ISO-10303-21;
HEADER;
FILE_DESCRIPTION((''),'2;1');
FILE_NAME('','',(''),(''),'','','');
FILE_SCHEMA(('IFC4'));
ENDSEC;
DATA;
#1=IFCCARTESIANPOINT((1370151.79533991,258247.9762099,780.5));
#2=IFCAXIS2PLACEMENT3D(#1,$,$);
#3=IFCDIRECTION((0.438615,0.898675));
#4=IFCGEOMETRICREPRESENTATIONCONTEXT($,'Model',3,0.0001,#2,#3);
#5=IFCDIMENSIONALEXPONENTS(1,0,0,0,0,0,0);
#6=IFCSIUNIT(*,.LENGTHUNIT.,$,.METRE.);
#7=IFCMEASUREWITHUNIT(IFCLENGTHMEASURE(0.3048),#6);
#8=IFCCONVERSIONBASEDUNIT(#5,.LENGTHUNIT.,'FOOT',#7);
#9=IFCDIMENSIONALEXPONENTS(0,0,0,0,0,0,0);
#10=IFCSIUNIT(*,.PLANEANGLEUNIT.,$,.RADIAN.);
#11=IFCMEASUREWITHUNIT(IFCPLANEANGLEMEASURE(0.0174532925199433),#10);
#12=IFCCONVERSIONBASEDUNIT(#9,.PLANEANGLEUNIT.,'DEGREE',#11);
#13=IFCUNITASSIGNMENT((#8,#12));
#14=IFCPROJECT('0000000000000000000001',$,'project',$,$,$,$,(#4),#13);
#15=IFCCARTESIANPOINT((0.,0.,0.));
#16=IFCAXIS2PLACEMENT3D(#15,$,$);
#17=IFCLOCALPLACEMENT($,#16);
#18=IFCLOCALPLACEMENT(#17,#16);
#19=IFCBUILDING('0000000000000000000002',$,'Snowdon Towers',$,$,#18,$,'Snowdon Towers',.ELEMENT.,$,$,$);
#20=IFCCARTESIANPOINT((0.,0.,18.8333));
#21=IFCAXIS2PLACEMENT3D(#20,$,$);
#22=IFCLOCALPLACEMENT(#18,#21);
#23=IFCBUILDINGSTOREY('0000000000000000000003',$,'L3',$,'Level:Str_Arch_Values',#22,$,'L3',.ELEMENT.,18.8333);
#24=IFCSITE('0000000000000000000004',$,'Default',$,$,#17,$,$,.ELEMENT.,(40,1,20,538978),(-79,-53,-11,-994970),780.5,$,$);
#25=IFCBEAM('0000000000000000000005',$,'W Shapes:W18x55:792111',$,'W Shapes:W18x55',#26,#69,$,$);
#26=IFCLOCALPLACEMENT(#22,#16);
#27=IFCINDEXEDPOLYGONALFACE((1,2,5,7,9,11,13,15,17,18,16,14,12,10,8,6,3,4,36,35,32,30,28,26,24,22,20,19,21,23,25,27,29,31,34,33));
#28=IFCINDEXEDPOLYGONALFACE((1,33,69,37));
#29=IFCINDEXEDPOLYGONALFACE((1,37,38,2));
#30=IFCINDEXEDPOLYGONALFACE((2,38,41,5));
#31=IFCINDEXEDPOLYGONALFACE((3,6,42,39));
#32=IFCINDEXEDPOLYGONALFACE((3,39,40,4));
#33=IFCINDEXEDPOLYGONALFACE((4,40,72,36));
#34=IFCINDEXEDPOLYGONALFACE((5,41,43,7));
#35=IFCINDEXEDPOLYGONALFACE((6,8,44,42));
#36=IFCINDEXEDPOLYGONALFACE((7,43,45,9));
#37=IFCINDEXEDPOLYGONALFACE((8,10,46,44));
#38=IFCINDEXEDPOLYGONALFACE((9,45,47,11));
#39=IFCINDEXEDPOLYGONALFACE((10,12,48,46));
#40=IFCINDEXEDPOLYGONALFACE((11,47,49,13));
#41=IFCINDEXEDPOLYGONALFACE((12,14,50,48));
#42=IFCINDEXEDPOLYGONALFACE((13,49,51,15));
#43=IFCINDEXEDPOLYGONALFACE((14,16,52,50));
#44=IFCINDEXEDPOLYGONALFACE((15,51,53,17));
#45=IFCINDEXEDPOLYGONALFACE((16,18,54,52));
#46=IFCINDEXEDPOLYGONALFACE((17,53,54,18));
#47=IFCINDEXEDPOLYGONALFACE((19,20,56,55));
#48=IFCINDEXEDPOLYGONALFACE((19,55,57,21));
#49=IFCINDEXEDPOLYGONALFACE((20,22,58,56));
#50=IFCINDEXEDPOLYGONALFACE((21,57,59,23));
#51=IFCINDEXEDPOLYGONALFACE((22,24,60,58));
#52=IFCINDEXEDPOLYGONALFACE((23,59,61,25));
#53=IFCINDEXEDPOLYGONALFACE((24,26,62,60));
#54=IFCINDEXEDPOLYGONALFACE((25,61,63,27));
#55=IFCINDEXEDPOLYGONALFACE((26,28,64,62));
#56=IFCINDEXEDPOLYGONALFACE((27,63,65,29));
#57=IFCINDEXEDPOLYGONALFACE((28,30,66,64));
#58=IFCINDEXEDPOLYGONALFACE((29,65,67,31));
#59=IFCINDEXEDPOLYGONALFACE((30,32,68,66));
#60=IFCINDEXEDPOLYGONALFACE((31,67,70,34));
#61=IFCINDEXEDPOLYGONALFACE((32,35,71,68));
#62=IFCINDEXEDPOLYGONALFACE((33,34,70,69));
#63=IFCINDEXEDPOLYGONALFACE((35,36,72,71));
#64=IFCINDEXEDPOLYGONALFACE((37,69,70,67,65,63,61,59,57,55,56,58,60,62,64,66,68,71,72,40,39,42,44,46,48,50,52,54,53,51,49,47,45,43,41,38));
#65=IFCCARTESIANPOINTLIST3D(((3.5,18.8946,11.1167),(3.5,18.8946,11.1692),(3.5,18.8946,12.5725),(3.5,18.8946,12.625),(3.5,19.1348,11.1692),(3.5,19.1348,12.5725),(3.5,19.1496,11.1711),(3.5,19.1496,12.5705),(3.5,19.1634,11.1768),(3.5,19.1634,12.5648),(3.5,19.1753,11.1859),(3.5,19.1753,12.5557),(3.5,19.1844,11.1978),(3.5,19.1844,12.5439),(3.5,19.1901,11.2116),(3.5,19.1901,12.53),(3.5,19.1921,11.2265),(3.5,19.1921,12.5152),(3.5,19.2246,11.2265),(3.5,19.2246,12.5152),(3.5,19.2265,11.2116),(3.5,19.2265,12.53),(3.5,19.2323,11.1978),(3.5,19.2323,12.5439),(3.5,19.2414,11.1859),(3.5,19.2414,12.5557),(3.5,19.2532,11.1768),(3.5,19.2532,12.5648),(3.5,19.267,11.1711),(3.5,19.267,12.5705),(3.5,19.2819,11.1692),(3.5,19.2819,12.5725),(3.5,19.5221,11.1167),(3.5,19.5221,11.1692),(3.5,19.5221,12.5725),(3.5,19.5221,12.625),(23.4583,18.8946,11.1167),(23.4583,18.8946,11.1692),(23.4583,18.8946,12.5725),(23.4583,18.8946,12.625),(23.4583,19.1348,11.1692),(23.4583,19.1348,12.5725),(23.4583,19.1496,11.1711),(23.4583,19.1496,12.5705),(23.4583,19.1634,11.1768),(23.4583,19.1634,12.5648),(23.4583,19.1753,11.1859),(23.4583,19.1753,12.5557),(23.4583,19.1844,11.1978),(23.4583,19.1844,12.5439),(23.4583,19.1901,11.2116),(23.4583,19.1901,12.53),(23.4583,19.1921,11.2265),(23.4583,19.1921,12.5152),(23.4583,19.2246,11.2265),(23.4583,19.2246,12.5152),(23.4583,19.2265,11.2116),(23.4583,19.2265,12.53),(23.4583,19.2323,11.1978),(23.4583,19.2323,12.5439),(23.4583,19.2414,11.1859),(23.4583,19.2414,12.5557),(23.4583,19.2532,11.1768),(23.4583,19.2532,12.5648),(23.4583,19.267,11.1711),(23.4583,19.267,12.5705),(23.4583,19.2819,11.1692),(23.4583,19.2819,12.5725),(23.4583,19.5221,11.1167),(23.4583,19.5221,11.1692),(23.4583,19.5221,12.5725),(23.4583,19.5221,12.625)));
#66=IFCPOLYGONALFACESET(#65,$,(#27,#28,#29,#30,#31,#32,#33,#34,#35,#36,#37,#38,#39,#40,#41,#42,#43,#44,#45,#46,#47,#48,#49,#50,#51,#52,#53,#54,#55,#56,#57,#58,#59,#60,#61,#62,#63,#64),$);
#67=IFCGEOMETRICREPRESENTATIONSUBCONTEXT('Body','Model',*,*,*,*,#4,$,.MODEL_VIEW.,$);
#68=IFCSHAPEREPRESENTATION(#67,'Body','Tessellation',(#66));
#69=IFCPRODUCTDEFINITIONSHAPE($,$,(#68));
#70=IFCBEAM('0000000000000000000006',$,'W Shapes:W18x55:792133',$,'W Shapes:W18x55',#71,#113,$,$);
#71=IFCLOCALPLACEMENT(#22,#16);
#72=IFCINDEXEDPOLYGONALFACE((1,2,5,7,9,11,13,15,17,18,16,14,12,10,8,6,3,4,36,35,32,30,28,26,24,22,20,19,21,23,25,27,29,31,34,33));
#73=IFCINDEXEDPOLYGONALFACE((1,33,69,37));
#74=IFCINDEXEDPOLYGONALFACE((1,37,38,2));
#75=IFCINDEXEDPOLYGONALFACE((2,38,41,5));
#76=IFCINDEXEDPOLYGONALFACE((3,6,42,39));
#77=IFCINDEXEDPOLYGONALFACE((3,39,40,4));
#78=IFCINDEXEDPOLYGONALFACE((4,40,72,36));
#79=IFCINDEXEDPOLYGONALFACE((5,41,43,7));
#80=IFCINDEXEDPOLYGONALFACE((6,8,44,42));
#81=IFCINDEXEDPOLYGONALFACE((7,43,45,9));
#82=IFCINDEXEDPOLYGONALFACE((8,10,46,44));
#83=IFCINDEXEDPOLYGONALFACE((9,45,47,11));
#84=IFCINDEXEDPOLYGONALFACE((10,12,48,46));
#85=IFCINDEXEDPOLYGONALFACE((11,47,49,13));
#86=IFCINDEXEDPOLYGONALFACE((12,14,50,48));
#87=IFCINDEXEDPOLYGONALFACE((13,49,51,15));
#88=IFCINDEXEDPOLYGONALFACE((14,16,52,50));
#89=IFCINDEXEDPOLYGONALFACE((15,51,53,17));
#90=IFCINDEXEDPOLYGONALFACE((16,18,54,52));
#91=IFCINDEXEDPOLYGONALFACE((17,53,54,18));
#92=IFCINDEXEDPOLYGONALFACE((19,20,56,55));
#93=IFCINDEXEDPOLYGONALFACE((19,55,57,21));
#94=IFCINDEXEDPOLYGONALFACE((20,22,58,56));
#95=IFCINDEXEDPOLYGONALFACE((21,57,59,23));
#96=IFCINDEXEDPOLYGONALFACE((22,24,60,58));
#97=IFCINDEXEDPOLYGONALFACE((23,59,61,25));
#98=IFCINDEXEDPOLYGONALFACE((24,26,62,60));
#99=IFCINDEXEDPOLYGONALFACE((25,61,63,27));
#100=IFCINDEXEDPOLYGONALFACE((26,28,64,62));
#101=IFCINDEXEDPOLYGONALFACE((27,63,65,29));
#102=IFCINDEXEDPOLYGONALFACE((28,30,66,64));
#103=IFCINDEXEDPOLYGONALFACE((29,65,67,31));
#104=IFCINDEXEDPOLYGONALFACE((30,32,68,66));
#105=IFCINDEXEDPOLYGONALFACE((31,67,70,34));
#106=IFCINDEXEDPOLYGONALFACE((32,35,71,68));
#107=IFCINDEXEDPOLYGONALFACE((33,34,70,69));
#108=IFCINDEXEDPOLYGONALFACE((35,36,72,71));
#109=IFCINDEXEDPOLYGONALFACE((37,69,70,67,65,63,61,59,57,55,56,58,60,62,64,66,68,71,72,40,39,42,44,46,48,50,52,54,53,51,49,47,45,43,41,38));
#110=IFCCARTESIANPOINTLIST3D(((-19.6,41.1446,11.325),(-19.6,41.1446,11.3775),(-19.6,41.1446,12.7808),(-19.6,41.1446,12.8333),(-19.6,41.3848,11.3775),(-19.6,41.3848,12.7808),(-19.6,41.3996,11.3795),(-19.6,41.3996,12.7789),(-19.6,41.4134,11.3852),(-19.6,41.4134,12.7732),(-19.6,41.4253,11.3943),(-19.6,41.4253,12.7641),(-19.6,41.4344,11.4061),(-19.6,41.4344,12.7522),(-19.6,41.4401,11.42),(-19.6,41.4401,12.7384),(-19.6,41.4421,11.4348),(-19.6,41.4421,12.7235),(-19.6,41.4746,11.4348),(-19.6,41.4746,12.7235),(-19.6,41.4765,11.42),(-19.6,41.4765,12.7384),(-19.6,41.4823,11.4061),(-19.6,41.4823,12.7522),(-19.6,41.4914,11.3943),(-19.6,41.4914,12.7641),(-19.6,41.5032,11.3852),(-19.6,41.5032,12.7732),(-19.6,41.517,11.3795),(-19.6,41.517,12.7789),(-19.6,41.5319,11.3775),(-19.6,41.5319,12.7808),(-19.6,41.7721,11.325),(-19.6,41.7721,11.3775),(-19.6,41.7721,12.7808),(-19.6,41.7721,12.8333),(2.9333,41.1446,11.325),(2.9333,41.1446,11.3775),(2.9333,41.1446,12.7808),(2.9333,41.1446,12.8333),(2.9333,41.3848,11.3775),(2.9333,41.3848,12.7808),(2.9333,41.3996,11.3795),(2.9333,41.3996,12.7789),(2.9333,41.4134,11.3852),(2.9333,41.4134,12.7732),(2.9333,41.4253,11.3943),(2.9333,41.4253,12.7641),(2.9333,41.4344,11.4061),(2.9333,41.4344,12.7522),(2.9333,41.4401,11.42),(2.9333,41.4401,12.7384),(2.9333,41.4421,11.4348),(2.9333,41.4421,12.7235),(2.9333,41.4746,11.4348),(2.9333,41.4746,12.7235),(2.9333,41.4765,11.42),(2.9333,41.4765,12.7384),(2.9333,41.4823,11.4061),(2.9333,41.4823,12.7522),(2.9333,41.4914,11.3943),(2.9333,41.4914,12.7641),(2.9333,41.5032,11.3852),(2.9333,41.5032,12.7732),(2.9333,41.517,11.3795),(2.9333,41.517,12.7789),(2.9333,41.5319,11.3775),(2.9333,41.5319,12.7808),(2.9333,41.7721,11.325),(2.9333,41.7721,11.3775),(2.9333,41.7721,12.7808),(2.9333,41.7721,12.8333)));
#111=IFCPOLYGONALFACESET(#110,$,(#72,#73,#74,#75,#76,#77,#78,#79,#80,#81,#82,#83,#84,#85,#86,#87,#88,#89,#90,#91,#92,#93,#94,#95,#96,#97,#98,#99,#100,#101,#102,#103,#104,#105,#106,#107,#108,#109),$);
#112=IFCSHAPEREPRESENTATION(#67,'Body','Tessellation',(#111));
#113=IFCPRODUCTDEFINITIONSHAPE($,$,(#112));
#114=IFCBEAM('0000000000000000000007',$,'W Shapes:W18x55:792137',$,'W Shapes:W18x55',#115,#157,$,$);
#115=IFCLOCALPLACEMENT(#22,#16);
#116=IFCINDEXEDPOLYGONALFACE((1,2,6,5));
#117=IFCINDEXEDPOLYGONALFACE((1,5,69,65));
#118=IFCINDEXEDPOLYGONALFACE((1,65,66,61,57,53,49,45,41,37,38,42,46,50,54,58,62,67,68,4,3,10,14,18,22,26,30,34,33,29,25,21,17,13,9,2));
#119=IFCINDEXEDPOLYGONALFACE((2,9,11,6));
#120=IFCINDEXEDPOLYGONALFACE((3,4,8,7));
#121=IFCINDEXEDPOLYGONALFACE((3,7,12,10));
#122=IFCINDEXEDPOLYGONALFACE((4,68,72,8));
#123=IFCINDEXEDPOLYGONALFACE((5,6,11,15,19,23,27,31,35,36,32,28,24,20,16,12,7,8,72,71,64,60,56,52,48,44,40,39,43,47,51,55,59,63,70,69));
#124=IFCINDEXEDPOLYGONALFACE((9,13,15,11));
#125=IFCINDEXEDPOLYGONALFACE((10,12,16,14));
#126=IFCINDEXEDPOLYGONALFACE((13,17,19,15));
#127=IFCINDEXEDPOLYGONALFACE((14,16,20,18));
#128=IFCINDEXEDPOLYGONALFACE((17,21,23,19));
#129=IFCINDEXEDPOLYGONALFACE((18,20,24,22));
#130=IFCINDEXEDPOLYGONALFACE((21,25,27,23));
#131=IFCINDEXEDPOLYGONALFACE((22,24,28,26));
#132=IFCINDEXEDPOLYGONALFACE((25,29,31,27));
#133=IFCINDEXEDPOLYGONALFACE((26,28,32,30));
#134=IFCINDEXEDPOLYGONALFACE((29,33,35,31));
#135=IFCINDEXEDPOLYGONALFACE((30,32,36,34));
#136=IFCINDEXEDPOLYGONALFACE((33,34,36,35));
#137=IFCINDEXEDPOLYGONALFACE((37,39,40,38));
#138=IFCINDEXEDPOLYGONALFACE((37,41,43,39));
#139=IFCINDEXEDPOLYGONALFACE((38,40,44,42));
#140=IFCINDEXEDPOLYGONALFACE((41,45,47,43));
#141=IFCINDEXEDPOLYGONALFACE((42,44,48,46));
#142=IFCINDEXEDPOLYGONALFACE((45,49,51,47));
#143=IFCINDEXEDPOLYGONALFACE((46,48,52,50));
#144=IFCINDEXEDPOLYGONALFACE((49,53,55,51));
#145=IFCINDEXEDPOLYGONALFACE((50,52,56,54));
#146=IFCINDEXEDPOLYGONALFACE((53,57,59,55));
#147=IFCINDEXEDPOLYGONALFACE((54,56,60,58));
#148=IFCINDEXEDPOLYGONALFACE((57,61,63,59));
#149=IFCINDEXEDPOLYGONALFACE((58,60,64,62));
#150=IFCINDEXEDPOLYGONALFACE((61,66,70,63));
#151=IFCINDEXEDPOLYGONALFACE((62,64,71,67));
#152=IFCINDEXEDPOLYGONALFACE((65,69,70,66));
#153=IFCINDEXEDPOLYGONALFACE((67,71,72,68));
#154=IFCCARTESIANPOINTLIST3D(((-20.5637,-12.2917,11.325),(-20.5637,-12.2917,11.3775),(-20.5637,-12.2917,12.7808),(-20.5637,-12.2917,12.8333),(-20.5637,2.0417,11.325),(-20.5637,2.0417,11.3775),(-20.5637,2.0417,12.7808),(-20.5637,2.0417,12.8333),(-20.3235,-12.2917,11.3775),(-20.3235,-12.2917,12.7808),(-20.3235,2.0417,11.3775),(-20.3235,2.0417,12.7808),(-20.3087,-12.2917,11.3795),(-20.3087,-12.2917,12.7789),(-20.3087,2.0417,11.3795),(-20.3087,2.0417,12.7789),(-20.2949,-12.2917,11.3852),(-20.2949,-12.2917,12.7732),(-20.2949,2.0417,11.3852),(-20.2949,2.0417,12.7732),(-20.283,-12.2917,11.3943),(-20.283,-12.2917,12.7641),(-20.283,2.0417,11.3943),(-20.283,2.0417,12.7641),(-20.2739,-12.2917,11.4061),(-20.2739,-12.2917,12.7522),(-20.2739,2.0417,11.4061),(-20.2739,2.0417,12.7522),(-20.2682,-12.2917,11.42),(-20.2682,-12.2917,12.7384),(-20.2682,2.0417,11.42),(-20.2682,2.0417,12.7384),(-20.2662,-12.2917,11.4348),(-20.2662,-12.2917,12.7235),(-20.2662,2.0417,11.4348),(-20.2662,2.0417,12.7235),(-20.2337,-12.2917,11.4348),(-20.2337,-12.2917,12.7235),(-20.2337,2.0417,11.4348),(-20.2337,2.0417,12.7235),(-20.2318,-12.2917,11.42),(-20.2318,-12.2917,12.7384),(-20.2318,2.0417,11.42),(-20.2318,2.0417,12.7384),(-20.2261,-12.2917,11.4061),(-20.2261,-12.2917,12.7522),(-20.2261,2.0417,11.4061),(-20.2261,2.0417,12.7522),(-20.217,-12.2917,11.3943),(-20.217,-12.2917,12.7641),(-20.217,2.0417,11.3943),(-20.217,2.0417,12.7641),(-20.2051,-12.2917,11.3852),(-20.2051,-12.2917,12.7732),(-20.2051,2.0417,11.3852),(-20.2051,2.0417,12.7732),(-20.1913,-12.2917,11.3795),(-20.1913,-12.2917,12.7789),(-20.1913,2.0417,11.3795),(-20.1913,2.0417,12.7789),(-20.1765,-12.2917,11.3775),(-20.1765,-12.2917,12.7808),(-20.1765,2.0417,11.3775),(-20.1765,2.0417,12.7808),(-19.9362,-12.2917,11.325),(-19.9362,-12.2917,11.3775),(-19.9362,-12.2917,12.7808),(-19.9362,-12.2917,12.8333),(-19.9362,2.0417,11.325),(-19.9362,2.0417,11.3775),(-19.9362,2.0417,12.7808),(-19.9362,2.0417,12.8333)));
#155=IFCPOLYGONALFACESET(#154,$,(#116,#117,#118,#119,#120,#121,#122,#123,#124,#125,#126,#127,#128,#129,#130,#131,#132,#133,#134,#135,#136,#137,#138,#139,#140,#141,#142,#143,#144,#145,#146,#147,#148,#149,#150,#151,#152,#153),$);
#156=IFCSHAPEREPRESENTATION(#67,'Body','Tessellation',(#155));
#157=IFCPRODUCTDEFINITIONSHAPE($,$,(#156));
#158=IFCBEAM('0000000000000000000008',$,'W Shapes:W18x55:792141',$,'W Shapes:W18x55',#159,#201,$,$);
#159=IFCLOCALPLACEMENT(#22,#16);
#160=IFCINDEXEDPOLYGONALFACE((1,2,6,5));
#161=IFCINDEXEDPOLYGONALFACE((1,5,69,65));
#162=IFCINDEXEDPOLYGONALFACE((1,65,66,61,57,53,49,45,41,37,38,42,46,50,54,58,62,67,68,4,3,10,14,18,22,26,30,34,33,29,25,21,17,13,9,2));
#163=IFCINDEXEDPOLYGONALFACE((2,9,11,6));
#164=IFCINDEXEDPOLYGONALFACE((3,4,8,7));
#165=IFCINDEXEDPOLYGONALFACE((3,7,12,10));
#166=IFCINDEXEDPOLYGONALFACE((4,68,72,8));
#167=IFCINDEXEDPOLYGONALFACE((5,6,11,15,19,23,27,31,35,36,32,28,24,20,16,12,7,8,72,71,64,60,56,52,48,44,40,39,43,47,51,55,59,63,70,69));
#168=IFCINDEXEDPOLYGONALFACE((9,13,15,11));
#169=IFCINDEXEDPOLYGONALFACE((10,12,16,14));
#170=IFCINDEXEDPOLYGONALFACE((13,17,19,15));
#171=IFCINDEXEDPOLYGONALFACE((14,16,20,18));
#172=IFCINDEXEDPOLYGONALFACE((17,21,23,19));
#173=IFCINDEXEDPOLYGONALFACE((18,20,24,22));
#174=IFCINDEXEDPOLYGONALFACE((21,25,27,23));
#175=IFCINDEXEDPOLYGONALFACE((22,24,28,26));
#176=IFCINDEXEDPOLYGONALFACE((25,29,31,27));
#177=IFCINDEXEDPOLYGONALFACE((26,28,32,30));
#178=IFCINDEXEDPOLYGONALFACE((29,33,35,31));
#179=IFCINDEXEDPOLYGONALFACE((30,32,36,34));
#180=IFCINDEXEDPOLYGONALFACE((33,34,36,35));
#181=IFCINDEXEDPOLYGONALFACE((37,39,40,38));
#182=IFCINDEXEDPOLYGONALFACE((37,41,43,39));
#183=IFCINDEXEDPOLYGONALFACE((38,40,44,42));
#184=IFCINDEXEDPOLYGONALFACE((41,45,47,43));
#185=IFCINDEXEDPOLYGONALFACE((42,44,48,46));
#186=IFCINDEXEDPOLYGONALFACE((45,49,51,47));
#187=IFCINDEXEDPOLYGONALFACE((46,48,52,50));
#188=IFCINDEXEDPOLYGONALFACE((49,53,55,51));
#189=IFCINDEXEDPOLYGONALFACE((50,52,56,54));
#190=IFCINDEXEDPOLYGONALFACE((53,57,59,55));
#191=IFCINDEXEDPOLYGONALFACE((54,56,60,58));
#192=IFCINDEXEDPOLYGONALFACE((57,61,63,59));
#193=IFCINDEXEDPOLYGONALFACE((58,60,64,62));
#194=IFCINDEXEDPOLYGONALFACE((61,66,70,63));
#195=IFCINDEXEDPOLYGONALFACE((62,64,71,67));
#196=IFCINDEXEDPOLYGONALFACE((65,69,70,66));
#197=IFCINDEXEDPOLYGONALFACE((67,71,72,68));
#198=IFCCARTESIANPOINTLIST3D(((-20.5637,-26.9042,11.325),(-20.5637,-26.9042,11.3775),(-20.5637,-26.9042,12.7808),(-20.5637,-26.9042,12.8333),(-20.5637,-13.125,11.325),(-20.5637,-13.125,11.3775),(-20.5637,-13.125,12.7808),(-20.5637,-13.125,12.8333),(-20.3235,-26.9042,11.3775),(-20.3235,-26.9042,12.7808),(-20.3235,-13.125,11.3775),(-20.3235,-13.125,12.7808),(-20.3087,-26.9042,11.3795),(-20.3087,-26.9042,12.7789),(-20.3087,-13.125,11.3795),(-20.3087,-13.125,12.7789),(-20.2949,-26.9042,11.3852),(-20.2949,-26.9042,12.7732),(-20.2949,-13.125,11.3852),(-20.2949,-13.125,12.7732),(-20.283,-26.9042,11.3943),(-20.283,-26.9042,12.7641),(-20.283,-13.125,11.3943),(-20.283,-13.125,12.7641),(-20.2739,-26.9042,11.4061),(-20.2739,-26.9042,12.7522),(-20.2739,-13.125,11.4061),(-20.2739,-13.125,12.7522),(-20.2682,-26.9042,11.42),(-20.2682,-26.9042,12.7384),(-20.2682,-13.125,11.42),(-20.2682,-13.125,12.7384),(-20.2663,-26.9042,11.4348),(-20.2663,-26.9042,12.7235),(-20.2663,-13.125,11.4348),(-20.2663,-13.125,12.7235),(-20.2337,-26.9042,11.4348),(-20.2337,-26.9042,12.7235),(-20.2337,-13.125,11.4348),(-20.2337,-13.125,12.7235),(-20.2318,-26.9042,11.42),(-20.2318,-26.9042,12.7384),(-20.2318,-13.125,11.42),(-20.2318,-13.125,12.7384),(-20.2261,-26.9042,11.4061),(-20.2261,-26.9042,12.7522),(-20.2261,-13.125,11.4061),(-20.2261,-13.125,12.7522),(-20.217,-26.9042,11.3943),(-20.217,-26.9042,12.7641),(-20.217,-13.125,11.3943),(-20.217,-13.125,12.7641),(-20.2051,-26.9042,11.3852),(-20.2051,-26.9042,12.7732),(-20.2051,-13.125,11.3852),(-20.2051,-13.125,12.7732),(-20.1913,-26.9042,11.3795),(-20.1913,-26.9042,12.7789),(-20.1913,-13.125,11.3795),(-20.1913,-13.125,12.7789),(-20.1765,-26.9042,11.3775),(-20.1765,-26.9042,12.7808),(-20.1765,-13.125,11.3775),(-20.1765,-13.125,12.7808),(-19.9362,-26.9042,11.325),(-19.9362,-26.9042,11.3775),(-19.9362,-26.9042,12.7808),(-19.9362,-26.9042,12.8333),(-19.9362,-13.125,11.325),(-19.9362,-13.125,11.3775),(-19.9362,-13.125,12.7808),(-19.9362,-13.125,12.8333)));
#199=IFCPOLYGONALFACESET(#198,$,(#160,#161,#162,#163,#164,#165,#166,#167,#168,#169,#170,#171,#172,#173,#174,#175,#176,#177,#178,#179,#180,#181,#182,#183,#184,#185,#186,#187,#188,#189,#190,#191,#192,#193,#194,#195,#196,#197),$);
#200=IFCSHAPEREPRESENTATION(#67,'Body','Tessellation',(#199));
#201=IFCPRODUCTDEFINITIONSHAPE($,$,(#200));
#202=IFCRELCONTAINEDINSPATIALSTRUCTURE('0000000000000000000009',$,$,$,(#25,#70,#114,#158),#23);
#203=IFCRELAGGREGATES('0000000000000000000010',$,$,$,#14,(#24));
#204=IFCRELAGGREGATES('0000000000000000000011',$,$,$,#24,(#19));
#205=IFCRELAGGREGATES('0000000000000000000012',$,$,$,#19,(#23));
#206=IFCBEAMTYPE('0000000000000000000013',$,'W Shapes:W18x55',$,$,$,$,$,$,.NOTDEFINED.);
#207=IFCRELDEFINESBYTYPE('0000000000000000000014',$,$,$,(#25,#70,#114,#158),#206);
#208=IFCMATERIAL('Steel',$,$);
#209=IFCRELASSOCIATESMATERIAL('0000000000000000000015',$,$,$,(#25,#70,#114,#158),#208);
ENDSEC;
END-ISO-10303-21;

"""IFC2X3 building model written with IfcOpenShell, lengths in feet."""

from ifc_helpers import new_model, entity, si_unit, converted_unit, direction, frame, frame_2d, origin, place, context, subcontext, project, spatial, i_section, extrude, material, type_object, element, save


model = new_model("IFC2X3")

# Units and contexts
model_context = context("Model", 3, precision=0.0001, world=frame((1370151.79533991, 258247.9762099, 780.5)), true_north=direction((0.438615, 0.898675)))
body_context = subcontext(model_context, "Body", "Model", "MODEL_VIEW")
ifc_project = project(units=[converted_unit("LENGTHUNIT", "FOOT", entity("IfcLengthMeasure", 0.3048), si_unit("LENGTHUNIT", "METRE"), dimensions=[1, 0, 0, 0, 0, 0, 0]), converted_unit("PLANEANGLEUNIT", "DEGREE", entity("IfcPlaneAngleMeasure", 0.0174532925199433), si_unit("PLANEANGLEUNIT", "RADIAN"), dimensions=[0, 0, 0, 0, 0, 0, 0])], contexts=[model_context])

# Site, building, storey
site_placement = place(None, origin())
site = spatial("IfcSite", under=ifc_project, at=site_placement, Name="Default", CompositionType="ELEMENT", RefLatitude=(40, 1, 20, 538978), RefLongitude=(-79, -53, -11, -994970), RefElevation=780.5)
building_placement = place(site_placement, origin())
building = spatial("IfcBuilding", under=site, at=building_placement, Name="Snowdon Towers", LongName="Snowdon Towers", CompositionType="ELEMENT")
storey_placement = place(building_placement, frame((0.0, 0.0, 18.8333)))
storey = spatial("IfcBuildingStorey", under=building, at=storey_placement, Name="L3", ObjectType="Level:Str_Arch_Values", LongName="L3", CompositionType="ELEMENT", Elevation=18.8333)

# Beams
ifc_material_1 = material(Name="Steel")
beam_type = type_object("IfcBeamType", Name="W Shapes:W18x55", PredefinedType="NOTDEFINED")
beam_1_placement = place(storey_placement, frame((3.5, 19.2083, 12.8333)))
element("IfcBeam", 1, at=beam_1_placement, inside=storey, type_object=beam_type, material=ifc_material_1, Name="W Shapes:W18x55:792111", ObjectType="W Shapes:W18x55", context=body_context, shape_type="SweptSolid", body=[
    extrude(i_section(OverallWidth=0.6275, OverallDepth=1.5083, WebThickness=0.0325, FlangeThickness=0.0525, FilletRadius=0.0573, at=frame_2d((0.0, 0.0), x_axis=(0.0, 1.0))), frame((0.0, 0.0, -0.9625), z_axis=(1.0, 0.0, 0.0), x_axis=(0.0, 0.0, -1.0)), (0.0, 0.0, 1.0), 19.9583),
])
beam_2_placement = place(storey_placement, frame((-20.25, 41.4583, 12.8333)))
element("IfcBeam", 2, at=beam_2_placement, inside=storey, type_object=beam_type, material=ifc_material_1, Name="W Shapes:W18x55:792133", ObjectType="W Shapes:W18x55", context=body_context, shape_type="SweptSolid", body=[
    extrude(i_section(OverallWidth=0.6275, OverallDepth=1.5083, WebThickness=0.0325, FlangeThickness=0.0525, FilletRadius=0.0573, at=frame_2d((0.0, 0.0), x_axis=(0.0, 1.0))), frame((0.65, 0.0, -0.7542), z_axis=(1.0, 0.0, 0.0), x_axis=(0.0, 0.0, -1.0)), (0.0, 0.0, 1.0), 22.5333),
])
beam_3_placement = place(storey_placement, frame((-20.25, 2.5, 12.8333), z_axis=(0.0, 0.0, 1.0), x_axis=(0.0, -1.0, 0.0)))
element("IfcBeam", 3, at=beam_3_placement, inside=storey, type_object=beam_type, material=ifc_material_1, Name="W Shapes:W18x55:792137", ObjectType="W Shapes:W18x55", context=body_context, shape_type="SweptSolid", body=[
    extrude(i_section(OverallWidth=0.6275, OverallDepth=1.5083, WebThickness=0.0325, FlangeThickness=0.0525, FilletRadius=0.0573, at=frame_2d((0.0, 0.0), x_axis=(0.0, 1.0))), frame((0.4583, 0.0, -0.7542), z_axis=(1.0, 0.0, 0.0), x_axis=(0.0, 0.0, -1.0)), (0.0, 0.0, 1.0), 14.3333),
])
beam_4_placement = place(storey_placement, frame((-20.25, -12.7083, 12.8333), z_axis=(0.0, 0.0, 1.0), x_axis=(0.0, -1.0, 0.0)))
element("IfcBeam", 4, at=beam_4_placement, inside=storey, type_object=beam_type, material=ifc_material_1, Name="W Shapes:W18x55:792141", ObjectType="W Shapes:W18x55", context=body_context, shape_type="SweptSolid", body=[
    extrude(i_section(OverallWidth=0.6275, OverallDepth=1.5083, WebThickness=0.0325, FlangeThickness=0.0525, FilletRadius=0.0573, at=frame_2d((0.0, 0.0), x_axis=(0.0, 1.0))), frame((0.4167, 0.0, -0.7542), z_axis=(1.0, 0.0, 0.0), x_axis=(0.0, 0.0, -1.0)), (0.0, 0.0, 1.0), 13.7792),
])

save(model, "model.ifc")
